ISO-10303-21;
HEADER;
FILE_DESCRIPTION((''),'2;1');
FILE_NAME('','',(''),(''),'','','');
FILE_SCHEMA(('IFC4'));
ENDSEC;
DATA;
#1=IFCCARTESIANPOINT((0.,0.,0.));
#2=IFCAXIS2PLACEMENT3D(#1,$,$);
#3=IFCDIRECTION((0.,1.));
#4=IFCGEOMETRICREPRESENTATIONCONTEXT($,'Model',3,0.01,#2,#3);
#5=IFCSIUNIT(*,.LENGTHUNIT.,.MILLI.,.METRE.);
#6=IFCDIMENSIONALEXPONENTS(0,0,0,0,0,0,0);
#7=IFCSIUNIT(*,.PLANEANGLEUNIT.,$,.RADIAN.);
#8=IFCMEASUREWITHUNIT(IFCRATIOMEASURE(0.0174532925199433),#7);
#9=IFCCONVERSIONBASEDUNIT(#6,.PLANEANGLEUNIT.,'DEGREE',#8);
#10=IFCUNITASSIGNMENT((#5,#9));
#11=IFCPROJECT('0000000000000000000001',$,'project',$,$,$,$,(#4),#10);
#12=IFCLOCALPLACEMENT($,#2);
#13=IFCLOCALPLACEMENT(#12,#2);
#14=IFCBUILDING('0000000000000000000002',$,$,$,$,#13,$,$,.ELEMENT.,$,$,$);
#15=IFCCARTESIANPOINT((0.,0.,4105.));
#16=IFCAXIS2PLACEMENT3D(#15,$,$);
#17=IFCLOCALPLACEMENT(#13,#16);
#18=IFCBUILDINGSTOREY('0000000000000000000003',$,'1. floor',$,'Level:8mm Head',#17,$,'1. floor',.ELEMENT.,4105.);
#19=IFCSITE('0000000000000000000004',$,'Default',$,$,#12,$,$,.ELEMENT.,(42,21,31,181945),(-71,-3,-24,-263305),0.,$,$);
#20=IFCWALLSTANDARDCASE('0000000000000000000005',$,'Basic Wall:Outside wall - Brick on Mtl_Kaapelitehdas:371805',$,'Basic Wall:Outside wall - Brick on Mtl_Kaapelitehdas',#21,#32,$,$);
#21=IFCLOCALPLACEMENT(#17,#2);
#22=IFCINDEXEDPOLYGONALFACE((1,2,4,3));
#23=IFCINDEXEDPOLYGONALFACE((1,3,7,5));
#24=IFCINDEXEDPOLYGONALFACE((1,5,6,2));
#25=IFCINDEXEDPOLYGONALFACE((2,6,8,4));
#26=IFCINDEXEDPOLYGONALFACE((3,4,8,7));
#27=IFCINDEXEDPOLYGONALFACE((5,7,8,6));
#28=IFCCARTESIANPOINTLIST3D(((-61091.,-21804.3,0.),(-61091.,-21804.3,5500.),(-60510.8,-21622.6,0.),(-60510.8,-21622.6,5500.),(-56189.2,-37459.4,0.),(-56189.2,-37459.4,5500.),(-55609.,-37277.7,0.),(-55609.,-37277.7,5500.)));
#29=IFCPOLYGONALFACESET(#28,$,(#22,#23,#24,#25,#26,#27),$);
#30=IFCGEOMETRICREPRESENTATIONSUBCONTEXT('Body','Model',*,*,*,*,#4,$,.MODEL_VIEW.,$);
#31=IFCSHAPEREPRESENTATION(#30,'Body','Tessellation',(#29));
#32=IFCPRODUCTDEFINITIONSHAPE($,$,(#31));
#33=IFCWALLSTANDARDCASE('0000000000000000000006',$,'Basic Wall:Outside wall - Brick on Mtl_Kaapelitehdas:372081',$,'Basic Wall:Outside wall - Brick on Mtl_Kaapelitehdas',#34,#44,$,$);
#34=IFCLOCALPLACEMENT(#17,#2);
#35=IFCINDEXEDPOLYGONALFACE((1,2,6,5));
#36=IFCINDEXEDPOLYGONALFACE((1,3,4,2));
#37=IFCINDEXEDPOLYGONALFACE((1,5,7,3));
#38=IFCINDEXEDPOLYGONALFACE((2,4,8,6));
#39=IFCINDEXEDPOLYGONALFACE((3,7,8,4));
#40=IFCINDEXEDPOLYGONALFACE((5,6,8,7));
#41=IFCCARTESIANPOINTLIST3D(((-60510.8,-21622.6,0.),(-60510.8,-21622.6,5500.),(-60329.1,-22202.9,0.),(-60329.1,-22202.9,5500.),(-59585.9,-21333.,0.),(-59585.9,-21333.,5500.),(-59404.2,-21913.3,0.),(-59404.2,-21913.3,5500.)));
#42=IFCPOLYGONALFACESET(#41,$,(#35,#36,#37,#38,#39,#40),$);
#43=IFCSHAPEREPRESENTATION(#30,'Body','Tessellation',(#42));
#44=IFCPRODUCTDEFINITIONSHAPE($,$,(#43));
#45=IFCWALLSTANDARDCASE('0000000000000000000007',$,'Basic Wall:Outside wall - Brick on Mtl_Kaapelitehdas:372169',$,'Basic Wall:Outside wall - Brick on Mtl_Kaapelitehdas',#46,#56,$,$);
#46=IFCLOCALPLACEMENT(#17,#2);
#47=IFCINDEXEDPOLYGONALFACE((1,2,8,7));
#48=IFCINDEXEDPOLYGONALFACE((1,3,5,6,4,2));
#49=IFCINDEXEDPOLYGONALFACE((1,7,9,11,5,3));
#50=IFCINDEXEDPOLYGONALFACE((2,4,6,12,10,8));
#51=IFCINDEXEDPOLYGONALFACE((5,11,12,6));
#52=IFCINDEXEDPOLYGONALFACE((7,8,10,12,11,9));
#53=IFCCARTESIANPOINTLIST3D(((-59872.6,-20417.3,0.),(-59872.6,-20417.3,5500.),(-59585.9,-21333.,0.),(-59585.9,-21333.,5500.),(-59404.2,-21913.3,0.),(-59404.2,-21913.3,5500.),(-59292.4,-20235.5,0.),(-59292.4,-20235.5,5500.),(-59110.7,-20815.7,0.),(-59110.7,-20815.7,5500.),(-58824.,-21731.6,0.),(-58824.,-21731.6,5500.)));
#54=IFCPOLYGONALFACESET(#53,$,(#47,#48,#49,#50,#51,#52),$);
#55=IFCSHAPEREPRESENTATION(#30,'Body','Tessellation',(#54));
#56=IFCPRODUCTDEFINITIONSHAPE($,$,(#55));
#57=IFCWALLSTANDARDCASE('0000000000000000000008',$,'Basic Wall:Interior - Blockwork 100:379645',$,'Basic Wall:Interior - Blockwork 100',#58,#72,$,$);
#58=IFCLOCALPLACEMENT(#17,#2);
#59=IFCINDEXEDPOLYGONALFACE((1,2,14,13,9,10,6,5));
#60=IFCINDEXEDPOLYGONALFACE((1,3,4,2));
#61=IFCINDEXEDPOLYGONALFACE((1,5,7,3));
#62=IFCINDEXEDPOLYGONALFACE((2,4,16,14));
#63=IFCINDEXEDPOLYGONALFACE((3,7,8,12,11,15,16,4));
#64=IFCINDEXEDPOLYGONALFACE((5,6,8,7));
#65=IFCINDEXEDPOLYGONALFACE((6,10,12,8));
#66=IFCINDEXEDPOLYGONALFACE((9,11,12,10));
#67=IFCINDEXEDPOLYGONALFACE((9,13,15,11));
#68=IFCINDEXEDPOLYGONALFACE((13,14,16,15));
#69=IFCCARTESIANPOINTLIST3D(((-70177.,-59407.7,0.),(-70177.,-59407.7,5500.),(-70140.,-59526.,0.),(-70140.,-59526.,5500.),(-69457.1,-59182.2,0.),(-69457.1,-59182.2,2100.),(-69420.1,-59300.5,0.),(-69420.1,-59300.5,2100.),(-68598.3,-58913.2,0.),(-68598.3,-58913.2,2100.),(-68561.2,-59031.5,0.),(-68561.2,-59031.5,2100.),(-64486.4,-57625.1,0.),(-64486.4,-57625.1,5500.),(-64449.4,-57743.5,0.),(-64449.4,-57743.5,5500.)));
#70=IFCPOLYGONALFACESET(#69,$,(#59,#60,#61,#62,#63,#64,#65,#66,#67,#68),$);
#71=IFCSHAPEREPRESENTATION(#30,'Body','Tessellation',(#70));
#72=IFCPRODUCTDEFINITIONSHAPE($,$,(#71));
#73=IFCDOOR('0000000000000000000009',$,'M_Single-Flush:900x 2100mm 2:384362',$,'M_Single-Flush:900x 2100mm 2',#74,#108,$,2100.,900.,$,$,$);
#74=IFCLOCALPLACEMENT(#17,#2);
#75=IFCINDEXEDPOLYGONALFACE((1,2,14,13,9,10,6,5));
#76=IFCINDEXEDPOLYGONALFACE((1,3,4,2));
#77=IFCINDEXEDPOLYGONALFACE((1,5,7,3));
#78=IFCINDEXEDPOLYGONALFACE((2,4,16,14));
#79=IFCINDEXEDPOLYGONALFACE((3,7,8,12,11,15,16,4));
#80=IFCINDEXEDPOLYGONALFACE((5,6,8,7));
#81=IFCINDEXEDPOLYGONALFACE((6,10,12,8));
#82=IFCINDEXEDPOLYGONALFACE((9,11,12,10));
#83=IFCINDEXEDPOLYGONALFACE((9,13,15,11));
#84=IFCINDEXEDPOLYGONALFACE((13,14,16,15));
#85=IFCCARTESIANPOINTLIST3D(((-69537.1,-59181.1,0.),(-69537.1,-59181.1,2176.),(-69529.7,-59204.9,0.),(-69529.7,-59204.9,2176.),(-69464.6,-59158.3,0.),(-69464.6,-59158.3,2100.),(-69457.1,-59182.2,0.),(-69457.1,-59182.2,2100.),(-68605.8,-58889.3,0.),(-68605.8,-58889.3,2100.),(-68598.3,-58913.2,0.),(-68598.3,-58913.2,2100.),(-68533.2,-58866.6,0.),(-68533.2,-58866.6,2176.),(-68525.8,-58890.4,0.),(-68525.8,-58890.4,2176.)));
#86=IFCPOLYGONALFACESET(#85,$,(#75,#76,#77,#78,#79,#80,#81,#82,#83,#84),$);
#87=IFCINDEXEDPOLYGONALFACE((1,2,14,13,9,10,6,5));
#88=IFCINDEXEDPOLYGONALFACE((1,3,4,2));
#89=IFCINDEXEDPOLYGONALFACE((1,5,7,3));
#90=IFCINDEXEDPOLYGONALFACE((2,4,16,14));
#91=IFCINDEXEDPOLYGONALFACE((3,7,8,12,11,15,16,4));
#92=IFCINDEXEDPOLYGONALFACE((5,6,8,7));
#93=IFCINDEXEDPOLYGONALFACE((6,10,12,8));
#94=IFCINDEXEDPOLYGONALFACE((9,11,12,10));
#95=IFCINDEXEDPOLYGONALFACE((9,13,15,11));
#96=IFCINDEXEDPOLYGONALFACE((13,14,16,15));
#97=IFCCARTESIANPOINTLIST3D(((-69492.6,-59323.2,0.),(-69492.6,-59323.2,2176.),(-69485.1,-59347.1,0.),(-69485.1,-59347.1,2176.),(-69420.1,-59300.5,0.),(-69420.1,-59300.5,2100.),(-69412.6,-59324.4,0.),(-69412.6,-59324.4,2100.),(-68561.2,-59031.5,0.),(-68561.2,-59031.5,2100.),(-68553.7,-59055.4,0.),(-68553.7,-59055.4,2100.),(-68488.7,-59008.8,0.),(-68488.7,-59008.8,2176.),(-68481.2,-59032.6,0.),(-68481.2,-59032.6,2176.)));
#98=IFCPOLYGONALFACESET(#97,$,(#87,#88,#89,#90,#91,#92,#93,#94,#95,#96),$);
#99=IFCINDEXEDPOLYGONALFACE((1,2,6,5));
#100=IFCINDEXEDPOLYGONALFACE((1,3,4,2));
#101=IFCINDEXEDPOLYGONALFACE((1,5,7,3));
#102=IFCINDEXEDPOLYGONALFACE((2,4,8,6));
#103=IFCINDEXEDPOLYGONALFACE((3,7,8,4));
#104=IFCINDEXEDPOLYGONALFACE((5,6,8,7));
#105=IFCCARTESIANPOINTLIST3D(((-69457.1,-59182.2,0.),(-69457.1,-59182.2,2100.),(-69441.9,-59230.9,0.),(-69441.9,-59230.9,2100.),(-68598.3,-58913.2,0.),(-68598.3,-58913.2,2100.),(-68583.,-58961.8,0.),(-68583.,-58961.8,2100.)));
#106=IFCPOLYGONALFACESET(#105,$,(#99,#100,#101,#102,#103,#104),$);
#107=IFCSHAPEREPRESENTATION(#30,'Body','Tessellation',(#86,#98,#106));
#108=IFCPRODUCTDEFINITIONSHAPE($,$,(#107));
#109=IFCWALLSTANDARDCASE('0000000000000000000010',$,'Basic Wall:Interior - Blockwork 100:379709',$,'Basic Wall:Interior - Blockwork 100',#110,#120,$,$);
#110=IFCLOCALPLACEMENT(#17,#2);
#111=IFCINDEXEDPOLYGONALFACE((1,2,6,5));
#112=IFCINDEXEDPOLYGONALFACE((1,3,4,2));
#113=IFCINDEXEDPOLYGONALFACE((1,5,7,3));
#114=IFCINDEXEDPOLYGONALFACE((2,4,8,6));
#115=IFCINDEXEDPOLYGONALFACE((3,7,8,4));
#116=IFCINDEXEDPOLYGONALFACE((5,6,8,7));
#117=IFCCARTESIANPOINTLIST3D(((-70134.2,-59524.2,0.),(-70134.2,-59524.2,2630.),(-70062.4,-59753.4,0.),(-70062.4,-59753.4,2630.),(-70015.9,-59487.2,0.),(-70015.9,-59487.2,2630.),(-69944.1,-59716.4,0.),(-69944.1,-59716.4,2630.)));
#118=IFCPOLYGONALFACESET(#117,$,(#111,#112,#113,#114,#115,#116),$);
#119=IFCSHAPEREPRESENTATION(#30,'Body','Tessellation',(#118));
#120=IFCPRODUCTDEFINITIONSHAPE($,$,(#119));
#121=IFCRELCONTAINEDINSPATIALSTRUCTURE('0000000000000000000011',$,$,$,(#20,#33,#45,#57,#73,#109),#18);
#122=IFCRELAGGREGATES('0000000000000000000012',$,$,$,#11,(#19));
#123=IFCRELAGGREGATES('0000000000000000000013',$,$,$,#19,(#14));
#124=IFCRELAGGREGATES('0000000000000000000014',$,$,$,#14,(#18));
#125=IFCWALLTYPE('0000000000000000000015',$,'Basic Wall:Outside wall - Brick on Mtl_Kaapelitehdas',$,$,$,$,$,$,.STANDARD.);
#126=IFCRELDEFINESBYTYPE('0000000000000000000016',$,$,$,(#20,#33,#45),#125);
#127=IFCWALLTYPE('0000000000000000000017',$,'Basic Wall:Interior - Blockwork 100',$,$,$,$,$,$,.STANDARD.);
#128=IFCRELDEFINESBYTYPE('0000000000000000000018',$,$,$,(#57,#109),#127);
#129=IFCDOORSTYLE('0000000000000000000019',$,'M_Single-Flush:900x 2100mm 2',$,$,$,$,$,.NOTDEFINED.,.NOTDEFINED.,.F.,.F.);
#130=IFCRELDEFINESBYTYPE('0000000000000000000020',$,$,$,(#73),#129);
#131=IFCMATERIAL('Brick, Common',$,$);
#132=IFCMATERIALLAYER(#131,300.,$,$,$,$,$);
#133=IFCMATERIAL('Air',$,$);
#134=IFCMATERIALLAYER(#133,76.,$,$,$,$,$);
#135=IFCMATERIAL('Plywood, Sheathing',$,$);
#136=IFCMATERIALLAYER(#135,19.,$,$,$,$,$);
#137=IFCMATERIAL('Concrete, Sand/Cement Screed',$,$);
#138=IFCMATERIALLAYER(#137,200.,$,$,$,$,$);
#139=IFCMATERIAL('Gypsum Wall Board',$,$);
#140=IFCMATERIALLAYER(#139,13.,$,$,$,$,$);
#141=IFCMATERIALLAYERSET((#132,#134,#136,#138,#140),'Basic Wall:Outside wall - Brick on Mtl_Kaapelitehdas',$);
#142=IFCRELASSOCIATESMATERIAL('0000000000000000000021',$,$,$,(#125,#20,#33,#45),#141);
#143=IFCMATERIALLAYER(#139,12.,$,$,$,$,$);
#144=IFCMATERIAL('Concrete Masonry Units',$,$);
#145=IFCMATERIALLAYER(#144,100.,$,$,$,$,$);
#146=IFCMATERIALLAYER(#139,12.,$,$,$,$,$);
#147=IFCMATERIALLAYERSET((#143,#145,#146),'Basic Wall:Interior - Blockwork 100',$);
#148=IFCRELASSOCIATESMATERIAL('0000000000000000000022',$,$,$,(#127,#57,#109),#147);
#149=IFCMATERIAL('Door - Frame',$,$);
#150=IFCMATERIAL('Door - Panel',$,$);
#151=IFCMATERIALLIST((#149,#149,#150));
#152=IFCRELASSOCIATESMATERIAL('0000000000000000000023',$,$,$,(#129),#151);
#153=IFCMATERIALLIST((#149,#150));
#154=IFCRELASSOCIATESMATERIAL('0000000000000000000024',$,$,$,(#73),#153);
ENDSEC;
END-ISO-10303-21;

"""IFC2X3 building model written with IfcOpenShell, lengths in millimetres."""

from ifc_helpers import new_model, entity, si_unit, converted_unit, direction, frame, frame_2d, origin, origin_2d_with_axis, place, context, subcontext, project, spatial, polyline, rectangle, outline, extrude, source, transform, mapped, material, material_list, layer, layer_set, layer_usage, type_object, type_shapes, element, fill, save


model = new_model("IFC2X3")

# Units and contexts
model_context = context("Model", 3, precision=0.01, world=origin(), true_north=direction((0.0, 1.0)))
body_context = subcontext(model_context, "Body", "Model", "MODEL_VIEW")
ifc_project = project(units=[si_unit("LENGTHUNIT", "METRE", prefix="MILLI"), converted_unit("PLANEANGLEUNIT", "DEGREE", entity("IfcRatioMeasure", 0.0174532925199433), si_unit("PLANEANGLEUNIT", "RADIAN"), dimensions=[0, 0, 0, 0, 0, 0, 0])], contexts=[model_context])

# Site, building, storey
site_placement = place(None, origin())
site = spatial("IfcSite", under=ifc_project, at=site_placement, Name="Default", CompositionType="ELEMENT", RefLatitude=(42, 21, 31, 181945), RefLongitude=(-71, -3, -24, -263305), RefElevation=0.0)
building_placement = place(site_placement, origin())
building = spatial("IfcBuilding", under=site, at=building_placement, CompositionType="ELEMENT")
storey_placement = place(building_placement, frame((0.0, 0.0, 4105.0)))
storey = spatial("IfcBuildingStorey", under=building, at=storey_placement, Name="1. floor", ObjectType="Level:8mm Head", LongName="1. floor", CompositionType="ELEMENT", Elevation=4105.0)

# Walls
ifc_material_1 = material(Name="Brick, Common")
ifc_layer_1 = layer(ifc_material_1, 300.0)
ifc_material_2 = material(Name="Air")
ifc_layer_2 = layer(ifc_material_2, 76.0)
ifc_material_3 = material(Name="Plywood, Sheathing")
ifc_layer_3 = layer(ifc_material_3, 19.0)
ifc_material_4 = material(Name="Concrete, Sand/Cement Screed")
ifc_layer_4 = layer(ifc_material_4, 200.0)
ifc_material_5 = material(Name="Gypsum Wall Board")
ifc_layer_5 = layer(ifc_material_5, 13.0)
ifc_layer_set_1 = layer_set([ifc_layer_1, ifc_layer_2, ifc_layer_3, ifc_layer_4, ifc_layer_5], Name="Basic Wall:Outside wall - Brick on Mtl_Kaapelitehdas")
ifc_layer_usage_1 = layer_usage(ifc_layer_set_1, "AXIS2", "NEGATIVE", 304.0)
wall_type_1 = type_object("IfcWallType", Name="Basic Wall:Outside wall - Brick on Mtl_Kaapelitehdas", PredefinedType="STANDARD", material=ifc_layer_set_1)
wall_1_placement = place(storey_placement, frame((-60800.9, -21713.5, 0.0), z_axis=(0.0, 0.0, 1.0), x_axis=(0.298805, -0.954314, 0.0)))
element("IfcWallStandardCase", 1, at=wall_1_placement, inside=storey, type_object=wall_type_1, material=ifc_layer_usage_1, Name="Basic Wall:Outside wall - Brick on Mtl_Kaapelitehdas:371805", ObjectType="Basic Wall:Outside wall - Brick on Mtl_Kaapelitehdas", context=body_context, shape_type="SweptSolid", body=[
    extrude(rectangle(XDim=16404.5, YDim=608.0, at=frame_2d((8202.3, 0.0), x_axis=(-1.0, 0.0))), origin(), (0.0, 0.0, 1.0), 5500.0),
])
ifc_layer_usage_2 = layer_usage(ifc_layer_set_1, "AXIS2", "NEGATIVE", 304.0)
wall_2_placement = place(storey_placement, frame((-60419.9, -21912.8, 0.0), z_axis=(0.0, 0.0, 1.0), x_axis=(0.954314, 0.298805, 0.0)))
element("IfcWallStandardCase", 2, at=wall_2_placement, inside=storey, type_object=wall_type_1, material=ifc_layer_usage_2, Name="Basic Wall:Outside wall - Brick on Mtl_Kaapelitehdas:372081", ObjectType="Basic Wall:Outside wall - Brick on Mtl_Kaapelitehdas", context=body_context, shape_type="SweptSolid", body=[
    extrude(rectangle(XDim=969.2, YDim=608.0, at=frame_2d((484.6, 0.0), x_axis=(-1.0, 0.0))), origin(), (0.0, 0.0, 1.0), 5500.0),
])
ifc_layer_usage_3 = layer_usage(ifc_layer_set_1, "AXIS2", "NEGATIVE", 304.0)
wall_3_placement = place(storey_placement, frame((-59114.1, -21822.4, 0.0), z_axis=(0.0, 0.0, 1.0), x_axis=(-0.298805, 0.954314, 0.0)))
element("IfcWallStandardCase", 3, at=wall_3_placement, inside=storey, type_object=wall_type_1, material=ifc_layer_usage_3, Name="Basic Wall:Outside wall - Brick on Mtl_Kaapelitehdas:372169", ObjectType="Basic Wall:Outside wall - Brick on Mtl_Kaapelitehdas", context=body_context, shape_type="SweptSolid", body=[
    extrude(outline(polyline([(1567.7, -304.0), (1567.6, 304.0), (608.0, 304.0), (0.0, 304.0), (0.0, -304.0), (959.7, -304.0), (1567.7, -304.0)])), origin(), (0.0, 0.0, 1.0), 5500.0),
])

# Wall, opening, door
ifc_layer_6 = layer(ifc_material_5, 12.0)
ifc_material_6 = material(Name="Concrete Masonry Units")
ifc_layer_7 = layer(ifc_material_6, 100.0)
ifc_layer_8 = layer(ifc_material_5, 12.0)
ifc_layer_set_2 = layer_set([ifc_layer_6, ifc_layer_7, ifc_layer_8], Name="Basic Wall:Interior - Blockwork 100")
ifc_layer_usage_4 = layer_usage(ifc_layer_set_2, "AXIS2", "NEGATIVE", 62.0)
wall_type_2 = type_object("IfcWallType", Name="Basic Wall:Interior - Blockwork 100", PredefinedType="STANDARD", material=ifc_layer_set_2)
wall_4_placement = place(storey_placement, frame((-64467.9, -57684.3, 0.0), z_axis=(0.0, 0.0, 1.0), x_axis=(-0.954277, -0.298924, 0.0)))
wall_4 = element("IfcWallStandardCase", 4, at=wall_4_placement, inside=storey, type_object=wall_type_2, material=ifc_layer_usage_4, Name="Basic Wall:Interior - Blockwork 100:379645", ObjectType="Basic Wall:Interior - Blockwork 100", context=body_context, shape_type="SweptSolid", body=[
    extrude(rectangle(XDim=5963.2, YDim=124.0, at=frame_2d((2981.6, 0.0), x_axis=(-1.0, 0.0))), origin(), (0.0, 0.0, 1.0), 5500.0),
])
opening_1_placement = place(wall_4_placement, frame((5208.9, 62.0, 0.0)))
opening_1 = element("IfcOpeningElement", 5, at=opening_1_placement, cuts=wall_4, ObjectType="Opening", context=body_context, shape_type="SweptSolid", body=[
    extrude(rectangle(XDim=900.0, YDim=2100.0, at=frame_2d((1050.0, 450.0), x_axis=(0.0, 1.0))), frame((0.0, 0.0, 0.0), z_axis=(0.0, -1.0, 0.0), x_axis=(0.0, 0.0, 1.0)), (0.0, 0.0, 1.0), 124.0),
])
ifc_material_7 = material(Name="Door - Frame")
ifc_material_8 = material(Name="Door - Panel")
ifc_material_list_1 = material_list([ifc_material_7, ifc_material_8])
ifc_material_list_2 = material_list([ifc_material_7, ifc_material_7, ifc_material_8])
door_style_1 = type_object("IfcDoorStyle", Name="M_Single-Flush:900x 2100mm 2", ConstructionType="NOTDEFINED", OperationType="NOTDEFINED", ParameterTakesPrecedence=False, Sizeable=False, material=ifc_material_list_2)
shared_shape_1 = source(origin(), body_context, "Body", "SweptSolid", [
    extrude(outline(polyline([(-526.0, -1107.0), (526.0, -1107.0), (526.0, 1069.0), (450.0, 1069.0), (450.0, -1031.0), (-450.0, -1031.0), (-450.0, 1069.0), (-526.0, 1069.0), (-526.0, -1107.0)])), frame((450.0, 124.0, 1069.0), z_axis=(0.0, 1.0, 0.0), x_axis=(1.0, 0.0, 0.0)), (0.0, 0.0, 1.0), 25.0),
    extrude(outline(polyline([(-1107.0, -526.0), (1069.0, -526.0), (1069.0, -450.0), (-1031.0, -450.0), (-1031.0, 450.0), (1069.0, 450.0), (1069.0, 526.0), (-1107.0, 526.0), (-1107.0, -526.0)])), frame((450.0, -25.0, 1069.0), z_axis=(0.0, 1.0, 0.0), x_axis=(0.0, 0.0, -1.0)), (0.0, 0.0, 1.0), 25.0),
    extrude(rectangle(XDim=51.0, YDim=900.0, at=origin_2d_with_axis()), frame((450.0, 98.5, 0.0), z_axis=(0.0, 0.0, 1.0), x_axis=(0.0, 1.0, 0.0)), (0.0, 0.0, 1.0), 2100.0),
])
type_shapes(door_style_1, [shared_shape_1])
door_1_placement = place(opening_1_placement, frame((0.0, 0.0, 0.0), z_axis=(0.0, 0.0, 1.0), x_axis=(-1.0, 0.0, 0.0)))
door_1 = element("IfcDoor", 6, at=door_1_placement, inside=storey, type_object=door_style_1, material=ifc_material_list_1, Name="M_Single-Flush:900x 2100mm 2:384362", ObjectType="M_Single-Flush:900x 2100mm 2", OverallHeight=2100.0, OverallWidth=900.0, context=body_context, shape_type="MappedRepresentation", body=[
    mapped(shared_shape_1, transform((0.0, 0.0, 0.0), scale=1.0)),
])
fill(opening_1, door_1)

# Wall
ifc_layer_usage_5 = layer_usage(ifc_layer_set_2, "AXIS2", "NEGATIVE", 62.0)
wall_5_placement = place(storey_placement, frame((-70075.1, -59505.7, 0.0), z_axis=(0.0, 0.0, 1.0), x_axis=(0.298924, -0.954277, 0.0)))
element("IfcWallStandardCase", 7, at=wall_5_placement, inside=storey, type_object=wall_type_2, material=ifc_layer_usage_5, Name="Basic Wall:Interior - Blockwork 100:379709", ObjectType="Basic Wall:Interior - Blockwork 100", context=body_context, shape_type="SweptSolid", body=[
    extrude(rectangle(XDim=240.2, YDim=124.0, at=frame_2d((120.1, 0.0), x_axis=(-1.0, 0.0))), origin(), (0.0, 0.0, 1.0), 2630.0),
])

save(model, "model.ifc")
